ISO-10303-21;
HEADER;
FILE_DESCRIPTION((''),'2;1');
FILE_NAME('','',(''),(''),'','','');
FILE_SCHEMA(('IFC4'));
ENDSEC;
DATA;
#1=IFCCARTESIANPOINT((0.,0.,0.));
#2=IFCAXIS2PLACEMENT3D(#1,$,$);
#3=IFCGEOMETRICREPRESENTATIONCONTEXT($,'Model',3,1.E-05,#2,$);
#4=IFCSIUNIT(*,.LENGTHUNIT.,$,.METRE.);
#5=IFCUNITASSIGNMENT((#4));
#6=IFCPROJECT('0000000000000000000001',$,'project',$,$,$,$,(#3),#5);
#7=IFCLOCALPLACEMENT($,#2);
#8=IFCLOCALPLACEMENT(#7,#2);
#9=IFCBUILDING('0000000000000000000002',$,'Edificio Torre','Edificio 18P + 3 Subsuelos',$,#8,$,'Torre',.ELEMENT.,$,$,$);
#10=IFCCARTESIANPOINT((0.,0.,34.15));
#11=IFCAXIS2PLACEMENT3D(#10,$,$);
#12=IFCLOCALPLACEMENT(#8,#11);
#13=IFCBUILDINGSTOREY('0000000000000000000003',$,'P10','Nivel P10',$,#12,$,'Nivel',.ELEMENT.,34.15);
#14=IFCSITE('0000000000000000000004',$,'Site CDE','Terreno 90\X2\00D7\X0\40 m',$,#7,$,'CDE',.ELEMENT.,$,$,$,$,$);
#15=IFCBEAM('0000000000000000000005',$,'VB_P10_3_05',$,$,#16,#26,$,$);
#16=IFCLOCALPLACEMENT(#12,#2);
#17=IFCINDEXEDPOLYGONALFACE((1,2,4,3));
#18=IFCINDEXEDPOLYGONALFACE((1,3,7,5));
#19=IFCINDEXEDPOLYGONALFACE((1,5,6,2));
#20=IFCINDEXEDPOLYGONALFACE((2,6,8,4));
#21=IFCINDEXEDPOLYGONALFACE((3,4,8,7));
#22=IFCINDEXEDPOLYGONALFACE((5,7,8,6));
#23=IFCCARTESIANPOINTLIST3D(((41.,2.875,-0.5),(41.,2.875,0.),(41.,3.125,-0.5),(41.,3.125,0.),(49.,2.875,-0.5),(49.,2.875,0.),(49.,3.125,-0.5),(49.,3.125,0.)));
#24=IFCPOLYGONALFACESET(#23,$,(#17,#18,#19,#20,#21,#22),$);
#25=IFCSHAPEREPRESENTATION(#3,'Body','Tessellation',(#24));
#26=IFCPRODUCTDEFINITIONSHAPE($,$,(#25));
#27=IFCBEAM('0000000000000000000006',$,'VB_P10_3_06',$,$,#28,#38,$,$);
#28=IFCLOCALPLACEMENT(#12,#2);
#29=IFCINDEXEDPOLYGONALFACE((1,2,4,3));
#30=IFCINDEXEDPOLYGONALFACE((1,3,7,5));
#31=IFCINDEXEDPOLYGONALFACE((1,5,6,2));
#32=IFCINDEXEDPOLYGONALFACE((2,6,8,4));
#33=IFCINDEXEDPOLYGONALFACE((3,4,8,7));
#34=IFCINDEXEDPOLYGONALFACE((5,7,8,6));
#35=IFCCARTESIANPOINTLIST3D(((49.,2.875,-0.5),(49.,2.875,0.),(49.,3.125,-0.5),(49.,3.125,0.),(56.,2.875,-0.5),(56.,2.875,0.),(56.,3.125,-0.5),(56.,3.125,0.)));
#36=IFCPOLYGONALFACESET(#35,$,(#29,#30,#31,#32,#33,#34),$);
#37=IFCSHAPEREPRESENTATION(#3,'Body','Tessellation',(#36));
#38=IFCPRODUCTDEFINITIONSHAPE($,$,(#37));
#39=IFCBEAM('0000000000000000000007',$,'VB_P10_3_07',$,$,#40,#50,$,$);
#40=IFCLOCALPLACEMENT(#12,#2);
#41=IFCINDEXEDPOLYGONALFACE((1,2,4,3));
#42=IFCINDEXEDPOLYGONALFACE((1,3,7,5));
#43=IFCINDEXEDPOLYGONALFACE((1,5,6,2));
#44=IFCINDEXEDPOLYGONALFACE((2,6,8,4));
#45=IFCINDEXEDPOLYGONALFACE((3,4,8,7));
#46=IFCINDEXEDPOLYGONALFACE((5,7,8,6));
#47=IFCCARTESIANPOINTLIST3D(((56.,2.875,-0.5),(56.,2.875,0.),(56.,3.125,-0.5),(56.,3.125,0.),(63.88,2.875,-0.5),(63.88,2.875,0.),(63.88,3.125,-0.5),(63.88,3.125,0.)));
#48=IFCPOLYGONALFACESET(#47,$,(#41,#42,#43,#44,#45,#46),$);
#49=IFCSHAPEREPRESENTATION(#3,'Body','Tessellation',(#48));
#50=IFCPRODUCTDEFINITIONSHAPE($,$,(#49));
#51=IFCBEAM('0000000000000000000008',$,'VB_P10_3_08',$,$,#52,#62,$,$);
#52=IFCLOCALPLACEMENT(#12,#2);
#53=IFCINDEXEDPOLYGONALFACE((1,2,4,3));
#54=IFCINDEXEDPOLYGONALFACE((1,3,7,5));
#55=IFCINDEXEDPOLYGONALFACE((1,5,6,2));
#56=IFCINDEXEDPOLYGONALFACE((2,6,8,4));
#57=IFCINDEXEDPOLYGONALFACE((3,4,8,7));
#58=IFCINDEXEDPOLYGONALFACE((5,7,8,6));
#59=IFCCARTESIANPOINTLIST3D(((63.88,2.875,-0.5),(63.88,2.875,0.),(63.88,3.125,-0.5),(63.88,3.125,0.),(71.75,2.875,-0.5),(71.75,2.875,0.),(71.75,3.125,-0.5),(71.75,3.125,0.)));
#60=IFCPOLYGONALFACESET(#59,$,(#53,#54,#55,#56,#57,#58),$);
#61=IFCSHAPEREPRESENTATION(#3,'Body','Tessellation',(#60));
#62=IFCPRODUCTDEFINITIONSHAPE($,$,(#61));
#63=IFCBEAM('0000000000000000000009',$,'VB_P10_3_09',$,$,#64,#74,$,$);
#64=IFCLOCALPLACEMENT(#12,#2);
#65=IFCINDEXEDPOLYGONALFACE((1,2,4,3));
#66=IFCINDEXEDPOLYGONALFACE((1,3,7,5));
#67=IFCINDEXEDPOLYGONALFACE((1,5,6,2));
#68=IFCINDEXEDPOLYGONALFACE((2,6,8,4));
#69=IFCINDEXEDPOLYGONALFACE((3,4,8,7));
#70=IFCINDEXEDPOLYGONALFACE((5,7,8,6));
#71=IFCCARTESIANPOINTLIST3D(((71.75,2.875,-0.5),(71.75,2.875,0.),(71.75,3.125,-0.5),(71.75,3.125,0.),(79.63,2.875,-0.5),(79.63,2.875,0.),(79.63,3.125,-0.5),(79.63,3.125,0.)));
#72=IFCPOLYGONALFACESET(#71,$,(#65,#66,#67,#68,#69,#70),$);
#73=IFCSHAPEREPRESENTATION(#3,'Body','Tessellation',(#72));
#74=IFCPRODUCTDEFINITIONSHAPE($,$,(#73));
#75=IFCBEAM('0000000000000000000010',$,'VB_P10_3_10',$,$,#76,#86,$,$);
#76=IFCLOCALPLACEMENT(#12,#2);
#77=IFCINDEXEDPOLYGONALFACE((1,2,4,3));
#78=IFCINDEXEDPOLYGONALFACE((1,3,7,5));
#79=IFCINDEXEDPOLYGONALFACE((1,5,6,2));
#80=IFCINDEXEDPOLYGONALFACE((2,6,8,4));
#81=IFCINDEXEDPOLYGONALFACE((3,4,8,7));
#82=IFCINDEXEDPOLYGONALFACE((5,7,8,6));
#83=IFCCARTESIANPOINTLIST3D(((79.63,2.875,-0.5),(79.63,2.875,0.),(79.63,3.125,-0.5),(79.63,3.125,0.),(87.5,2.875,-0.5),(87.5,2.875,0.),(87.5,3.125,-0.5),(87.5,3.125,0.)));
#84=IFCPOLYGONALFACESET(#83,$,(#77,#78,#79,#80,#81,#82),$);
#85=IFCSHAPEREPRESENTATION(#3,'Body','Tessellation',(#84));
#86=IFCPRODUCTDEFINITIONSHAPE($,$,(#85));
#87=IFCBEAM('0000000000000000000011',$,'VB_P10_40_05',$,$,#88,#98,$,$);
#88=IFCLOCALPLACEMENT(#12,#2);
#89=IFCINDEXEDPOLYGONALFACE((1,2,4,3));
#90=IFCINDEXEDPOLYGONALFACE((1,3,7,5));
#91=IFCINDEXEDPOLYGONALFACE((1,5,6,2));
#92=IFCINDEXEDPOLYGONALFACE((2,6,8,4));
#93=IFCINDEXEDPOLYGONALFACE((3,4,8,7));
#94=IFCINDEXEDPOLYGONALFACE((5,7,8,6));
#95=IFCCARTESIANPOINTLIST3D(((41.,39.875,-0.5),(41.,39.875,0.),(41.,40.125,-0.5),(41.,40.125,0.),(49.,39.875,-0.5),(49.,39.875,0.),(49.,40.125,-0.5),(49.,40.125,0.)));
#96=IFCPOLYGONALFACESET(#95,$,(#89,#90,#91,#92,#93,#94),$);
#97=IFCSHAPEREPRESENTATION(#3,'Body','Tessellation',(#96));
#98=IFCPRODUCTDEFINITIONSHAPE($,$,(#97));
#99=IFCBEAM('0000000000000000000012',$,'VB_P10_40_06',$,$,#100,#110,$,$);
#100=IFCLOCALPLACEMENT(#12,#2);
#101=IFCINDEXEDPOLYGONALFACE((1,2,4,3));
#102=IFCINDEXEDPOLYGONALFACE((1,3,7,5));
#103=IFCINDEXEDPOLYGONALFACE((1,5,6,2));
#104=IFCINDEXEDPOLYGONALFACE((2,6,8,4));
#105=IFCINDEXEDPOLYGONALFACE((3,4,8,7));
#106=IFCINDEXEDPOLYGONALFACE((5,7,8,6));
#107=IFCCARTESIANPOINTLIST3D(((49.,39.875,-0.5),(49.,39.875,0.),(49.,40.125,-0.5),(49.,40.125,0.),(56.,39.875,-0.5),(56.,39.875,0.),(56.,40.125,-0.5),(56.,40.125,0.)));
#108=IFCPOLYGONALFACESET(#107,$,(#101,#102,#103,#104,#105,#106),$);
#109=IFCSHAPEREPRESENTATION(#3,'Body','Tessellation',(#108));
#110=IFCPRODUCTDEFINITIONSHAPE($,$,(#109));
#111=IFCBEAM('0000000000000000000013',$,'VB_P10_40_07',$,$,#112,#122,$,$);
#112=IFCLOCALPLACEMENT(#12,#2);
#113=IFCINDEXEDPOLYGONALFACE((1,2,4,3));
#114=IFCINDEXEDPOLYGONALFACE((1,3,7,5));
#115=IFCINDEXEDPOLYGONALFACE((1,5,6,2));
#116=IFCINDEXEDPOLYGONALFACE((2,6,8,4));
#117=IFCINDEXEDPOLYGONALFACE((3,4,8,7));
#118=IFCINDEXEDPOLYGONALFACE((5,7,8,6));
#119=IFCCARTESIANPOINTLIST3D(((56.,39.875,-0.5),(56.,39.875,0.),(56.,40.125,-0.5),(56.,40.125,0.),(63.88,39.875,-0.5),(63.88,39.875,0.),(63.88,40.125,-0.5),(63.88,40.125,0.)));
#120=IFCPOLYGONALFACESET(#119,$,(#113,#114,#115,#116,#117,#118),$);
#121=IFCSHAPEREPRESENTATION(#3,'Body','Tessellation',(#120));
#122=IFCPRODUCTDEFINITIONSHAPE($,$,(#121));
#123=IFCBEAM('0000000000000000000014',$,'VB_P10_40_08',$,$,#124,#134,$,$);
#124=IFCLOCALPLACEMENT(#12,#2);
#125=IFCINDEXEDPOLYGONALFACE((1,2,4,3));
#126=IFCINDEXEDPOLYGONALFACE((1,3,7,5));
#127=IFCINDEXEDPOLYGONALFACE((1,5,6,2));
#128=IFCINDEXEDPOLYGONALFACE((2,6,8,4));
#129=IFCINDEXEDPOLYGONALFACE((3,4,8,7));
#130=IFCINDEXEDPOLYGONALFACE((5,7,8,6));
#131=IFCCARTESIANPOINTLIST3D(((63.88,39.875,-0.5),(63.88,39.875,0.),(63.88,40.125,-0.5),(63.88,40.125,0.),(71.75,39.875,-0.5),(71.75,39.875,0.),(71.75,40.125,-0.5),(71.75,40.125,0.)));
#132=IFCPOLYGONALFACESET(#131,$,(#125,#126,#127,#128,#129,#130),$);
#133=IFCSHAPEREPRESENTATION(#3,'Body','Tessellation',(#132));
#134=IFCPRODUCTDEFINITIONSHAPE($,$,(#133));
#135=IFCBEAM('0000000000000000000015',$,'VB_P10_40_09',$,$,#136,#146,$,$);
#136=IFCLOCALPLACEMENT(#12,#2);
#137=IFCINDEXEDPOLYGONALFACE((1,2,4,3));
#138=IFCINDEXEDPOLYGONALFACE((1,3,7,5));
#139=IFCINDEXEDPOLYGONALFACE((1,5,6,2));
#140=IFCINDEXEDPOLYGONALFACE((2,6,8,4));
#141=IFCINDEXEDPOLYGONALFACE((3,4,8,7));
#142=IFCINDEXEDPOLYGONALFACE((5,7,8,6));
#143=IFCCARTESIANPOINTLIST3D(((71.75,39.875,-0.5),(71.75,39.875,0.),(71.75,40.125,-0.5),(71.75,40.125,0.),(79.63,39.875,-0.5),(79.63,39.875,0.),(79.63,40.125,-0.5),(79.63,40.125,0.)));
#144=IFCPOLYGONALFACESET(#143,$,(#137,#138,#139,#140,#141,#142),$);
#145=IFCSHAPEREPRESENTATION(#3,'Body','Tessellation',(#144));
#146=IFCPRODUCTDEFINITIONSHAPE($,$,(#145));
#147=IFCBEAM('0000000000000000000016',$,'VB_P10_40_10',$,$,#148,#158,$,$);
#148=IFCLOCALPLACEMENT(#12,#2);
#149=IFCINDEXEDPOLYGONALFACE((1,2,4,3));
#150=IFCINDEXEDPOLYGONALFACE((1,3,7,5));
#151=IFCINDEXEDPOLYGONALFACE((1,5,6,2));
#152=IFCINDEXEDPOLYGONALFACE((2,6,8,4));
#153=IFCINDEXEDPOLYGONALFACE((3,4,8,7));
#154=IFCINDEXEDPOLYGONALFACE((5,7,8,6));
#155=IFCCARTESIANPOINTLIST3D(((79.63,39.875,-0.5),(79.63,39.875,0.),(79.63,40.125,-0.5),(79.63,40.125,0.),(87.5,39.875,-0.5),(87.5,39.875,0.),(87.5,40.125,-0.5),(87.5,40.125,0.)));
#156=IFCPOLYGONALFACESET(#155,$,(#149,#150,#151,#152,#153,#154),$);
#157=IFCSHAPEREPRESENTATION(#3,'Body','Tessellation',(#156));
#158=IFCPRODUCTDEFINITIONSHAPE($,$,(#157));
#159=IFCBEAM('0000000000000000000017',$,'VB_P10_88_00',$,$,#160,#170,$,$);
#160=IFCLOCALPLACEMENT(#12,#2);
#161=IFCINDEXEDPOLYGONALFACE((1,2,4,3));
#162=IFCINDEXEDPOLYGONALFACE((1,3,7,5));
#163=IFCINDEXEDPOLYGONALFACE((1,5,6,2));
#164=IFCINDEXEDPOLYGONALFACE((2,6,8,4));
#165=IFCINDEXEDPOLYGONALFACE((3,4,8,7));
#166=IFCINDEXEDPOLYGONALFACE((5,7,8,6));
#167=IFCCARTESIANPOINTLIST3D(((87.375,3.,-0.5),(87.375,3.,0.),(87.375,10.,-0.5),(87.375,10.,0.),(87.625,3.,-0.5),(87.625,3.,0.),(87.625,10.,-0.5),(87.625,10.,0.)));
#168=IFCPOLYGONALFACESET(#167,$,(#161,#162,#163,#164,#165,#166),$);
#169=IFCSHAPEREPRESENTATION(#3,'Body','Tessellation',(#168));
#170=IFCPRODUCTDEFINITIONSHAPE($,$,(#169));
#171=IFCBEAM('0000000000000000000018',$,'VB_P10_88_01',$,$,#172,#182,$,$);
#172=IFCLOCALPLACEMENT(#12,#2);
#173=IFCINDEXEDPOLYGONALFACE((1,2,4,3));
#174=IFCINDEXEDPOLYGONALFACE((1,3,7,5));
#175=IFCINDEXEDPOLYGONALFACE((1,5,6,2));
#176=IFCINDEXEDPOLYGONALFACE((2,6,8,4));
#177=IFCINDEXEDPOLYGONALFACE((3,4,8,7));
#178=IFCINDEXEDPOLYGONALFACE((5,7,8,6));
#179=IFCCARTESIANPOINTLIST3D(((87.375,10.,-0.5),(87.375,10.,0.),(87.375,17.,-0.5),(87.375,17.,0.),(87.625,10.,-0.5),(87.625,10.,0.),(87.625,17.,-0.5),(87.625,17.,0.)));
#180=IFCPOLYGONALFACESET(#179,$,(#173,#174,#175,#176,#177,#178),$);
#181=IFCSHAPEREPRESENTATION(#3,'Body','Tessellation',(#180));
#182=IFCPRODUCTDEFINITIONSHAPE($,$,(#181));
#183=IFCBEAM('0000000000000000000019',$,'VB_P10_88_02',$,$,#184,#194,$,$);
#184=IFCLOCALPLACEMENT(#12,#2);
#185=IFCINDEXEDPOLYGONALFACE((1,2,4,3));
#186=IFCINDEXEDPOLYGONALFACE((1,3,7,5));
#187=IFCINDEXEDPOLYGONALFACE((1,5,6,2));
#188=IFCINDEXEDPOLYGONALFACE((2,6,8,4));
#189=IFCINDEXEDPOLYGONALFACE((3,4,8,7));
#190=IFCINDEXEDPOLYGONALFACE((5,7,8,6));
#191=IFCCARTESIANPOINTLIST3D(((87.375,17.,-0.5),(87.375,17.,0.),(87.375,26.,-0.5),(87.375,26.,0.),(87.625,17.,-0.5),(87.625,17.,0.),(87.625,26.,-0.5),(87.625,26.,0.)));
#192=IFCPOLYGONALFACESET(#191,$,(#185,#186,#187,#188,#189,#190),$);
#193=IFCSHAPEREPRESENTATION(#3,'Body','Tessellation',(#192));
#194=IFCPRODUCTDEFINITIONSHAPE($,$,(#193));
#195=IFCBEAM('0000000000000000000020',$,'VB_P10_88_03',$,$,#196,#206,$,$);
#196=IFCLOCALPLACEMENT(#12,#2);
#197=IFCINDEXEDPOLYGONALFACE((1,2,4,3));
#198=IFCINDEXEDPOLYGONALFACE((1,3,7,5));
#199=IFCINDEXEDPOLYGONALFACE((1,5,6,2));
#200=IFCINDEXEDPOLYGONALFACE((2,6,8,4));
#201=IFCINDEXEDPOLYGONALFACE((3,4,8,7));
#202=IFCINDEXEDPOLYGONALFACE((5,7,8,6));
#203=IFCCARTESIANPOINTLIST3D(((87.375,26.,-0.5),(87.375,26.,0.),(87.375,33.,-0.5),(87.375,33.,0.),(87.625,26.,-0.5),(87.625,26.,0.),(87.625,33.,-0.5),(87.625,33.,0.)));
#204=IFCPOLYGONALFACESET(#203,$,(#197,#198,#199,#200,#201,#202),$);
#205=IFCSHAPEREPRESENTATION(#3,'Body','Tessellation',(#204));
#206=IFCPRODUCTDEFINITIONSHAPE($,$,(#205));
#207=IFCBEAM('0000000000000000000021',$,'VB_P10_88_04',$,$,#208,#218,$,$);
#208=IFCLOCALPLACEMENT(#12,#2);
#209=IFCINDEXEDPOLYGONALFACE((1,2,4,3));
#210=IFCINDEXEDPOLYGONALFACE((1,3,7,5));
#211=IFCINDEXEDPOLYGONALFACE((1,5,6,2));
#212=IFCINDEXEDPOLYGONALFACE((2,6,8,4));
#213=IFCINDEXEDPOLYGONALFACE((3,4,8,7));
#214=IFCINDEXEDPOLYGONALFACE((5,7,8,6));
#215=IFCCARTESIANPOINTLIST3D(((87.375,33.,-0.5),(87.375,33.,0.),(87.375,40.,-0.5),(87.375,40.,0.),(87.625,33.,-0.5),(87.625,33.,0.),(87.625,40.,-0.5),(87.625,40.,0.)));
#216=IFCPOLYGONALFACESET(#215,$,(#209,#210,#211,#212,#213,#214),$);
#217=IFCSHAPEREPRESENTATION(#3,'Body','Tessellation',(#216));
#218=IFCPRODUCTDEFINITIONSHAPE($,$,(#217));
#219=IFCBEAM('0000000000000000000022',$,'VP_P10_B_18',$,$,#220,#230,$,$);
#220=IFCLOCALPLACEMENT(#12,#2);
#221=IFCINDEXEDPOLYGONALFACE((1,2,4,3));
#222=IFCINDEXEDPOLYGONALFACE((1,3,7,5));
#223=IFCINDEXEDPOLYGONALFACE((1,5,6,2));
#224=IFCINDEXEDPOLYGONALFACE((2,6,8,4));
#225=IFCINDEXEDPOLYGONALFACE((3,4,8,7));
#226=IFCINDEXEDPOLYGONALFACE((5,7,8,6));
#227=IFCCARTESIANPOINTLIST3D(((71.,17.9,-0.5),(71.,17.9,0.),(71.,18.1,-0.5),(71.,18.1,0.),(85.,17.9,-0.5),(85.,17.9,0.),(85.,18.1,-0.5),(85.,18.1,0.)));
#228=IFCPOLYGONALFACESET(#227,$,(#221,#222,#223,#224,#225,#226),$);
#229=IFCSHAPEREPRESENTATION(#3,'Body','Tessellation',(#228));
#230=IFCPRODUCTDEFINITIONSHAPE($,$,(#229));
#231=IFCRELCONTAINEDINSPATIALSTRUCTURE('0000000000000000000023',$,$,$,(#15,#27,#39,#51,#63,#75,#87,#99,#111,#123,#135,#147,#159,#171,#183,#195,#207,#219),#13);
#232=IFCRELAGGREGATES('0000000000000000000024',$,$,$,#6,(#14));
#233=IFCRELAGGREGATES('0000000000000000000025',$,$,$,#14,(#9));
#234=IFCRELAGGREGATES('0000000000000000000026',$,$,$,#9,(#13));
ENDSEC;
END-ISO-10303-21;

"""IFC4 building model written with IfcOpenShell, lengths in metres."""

from ifc_helpers import new_model, si_unit, frame, origin, origin_2d, place, context, project, spatial, rectangle, extrude, element, save


model = new_model("IFC4")

# Units and contexts
model_context = context("Model", 3, precision=1e-05, world=origin())
ifc_project = project(units=[si_unit("LENGTHUNIT", "METRE")], contexts=[model_context])

# Site, building, storey
site_placement = place(None, origin())
site = spatial("IfcSite", under=ifc_project, at=site_placement, Name="Site CDE", Description="Terreno 90×40 m", LongName="CDE", CompositionType="ELEMENT")
building_placement = place(site_placement, origin())
building = spatial("IfcBuilding", under=site, at=building_placement, Name="Edificio Torre", Description="Edificio 18P + 3 Subsuelos", LongName="Torre", CompositionType="ELEMENT")
storey_placement = place(building_placement, frame((0.0, 0.0, 34.15)))
storey = spatial("IfcBuildingStorey", under=building, at=storey_placement, Name="P10", Description="Nivel P10", LongName="Nivel", CompositionType="ELEMENT", Elevation=34.15)

# Beams
beam_1_placement = place(storey_placement, frame((45.0, 3.0, -0.5)))
element("IfcBeam", 1, at=beam_1_placement, inside=storey, Name="VB_P10_3_05", context=model_context, shape_type="SweptSolid", body=[
    extrude(rectangle(XDim=8.0, YDim=0.25, at=origin_2d()), origin(), (0.0, 0.0, 1.0), 0.5),
])
beam_2_placement = place(storey_placement, frame((52.5, 3.0, -0.5)))
element("IfcBeam", 2, at=beam_2_placement, inside=storey, Name="VB_P10_3_06", context=model_context, shape_type="SweptSolid", body=[
    extrude(rectangle(XDim=7.0, YDim=0.25, at=origin_2d()), origin(), (0.0, 0.0, 1.0), 0.5),
])
beam_3_placement = place(storey_placement, frame((59.94, 3.0, -0.5)))
element("IfcBeam", 3, at=beam_3_placement, inside=storey, Name="VB_P10_3_07", context=model_context, shape_type="SweptSolid", body=[
    extrude(rectangle(XDim=7.88, YDim=0.25, at=origin_2d()), origin(), (0.0, 0.0, 1.0), 0.5),
])
beam_4_placement = place(storey_placement, frame((67.815, 3.0, -0.5)))
element("IfcBeam", 4, at=beam_4_placement, inside=storey, Name="VB_P10_3_08", context=model_context, shape_type="SweptSolid", body=[
    extrude(rectangle(XDim=7.87, YDim=0.25, at=origin_2d()), origin(), (0.0, 0.0, 1.0), 0.5),
])
beam_5_placement = place(storey_placement, frame((75.69, 3.0, -0.5)))
element("IfcBeam", 5, at=beam_5_placement, inside=storey, Name="VB_P10_3_09", context=model_context, shape_type="SweptSolid", body=[
    extrude(rectangle(XDim=7.88, YDim=0.25, at=origin_2d()), origin(), (0.0, 0.0, 1.0), 0.5),
])
beam_6_placement = place(storey_placement, frame((83.565, 3.0, -0.5)))
element("IfcBeam", 6, at=beam_6_placement, inside=storey, Name="VB_P10_3_10", context=model_context, shape_type="SweptSolid", body=[
    extrude(rectangle(XDim=7.87, YDim=0.25, at=origin_2d()), origin(), (0.0, 0.0, 1.0), 0.5),
])
beam_7_placement = place(storey_placement, frame((45.0, 40.0, -0.5)))
element("IfcBeam", 7, at=beam_7_placement, inside=storey, Name="VB_P10_40_05", context=model_context, shape_type="SweptSolid", body=[
    extrude(rectangle(XDim=8.0, YDim=0.25, at=origin_2d()), origin(), (0.0, 0.0, 1.0), 0.5),
])
beam_8_placement = place(storey_placement, frame((52.5, 40.0, -0.5)))
element("IfcBeam", 8, at=beam_8_placement, inside=storey, Name="VB_P10_40_06", context=model_context, shape_type="SweptSolid", body=[
    extrude(rectangle(XDim=7.0, YDim=0.25, at=origin_2d()), origin(), (0.0, 0.0, 1.0), 0.5),
])
beam_9_placement = place(storey_placement, frame((59.94, 40.0, -0.5)))
element("IfcBeam", 9, at=beam_9_placement, inside=storey, Name="VB_P10_40_07", context=model_context, shape_type="SweptSolid", body=[
    extrude(rectangle(XDim=7.88, YDim=0.25, at=origin_2d()), origin(), (0.0, 0.0, 1.0), 0.5),
])
beam_10_placement = place(storey_placement, frame((67.815, 40.0, -0.5)))
element("IfcBeam", 10, at=beam_10_placement, inside=storey, Name="VB_P10_40_08", context=model_context, shape_type="SweptSolid", body=[
    extrude(rectangle(XDim=7.87, YDim=0.25, at=origin_2d()), origin(), (0.0, 0.0, 1.0), 0.5),
])
beam_11_placement = place(storey_placement, frame((75.69, 40.0, -0.5)))
element("IfcBeam", 11, at=beam_11_placement, inside=storey, Name="VB_P10_40_09", context=model_context, shape_type="SweptSolid", body=[
    extrude(rectangle(XDim=7.88, YDim=0.25, at=origin_2d()), origin(), (0.0, 0.0, 1.0), 0.5),
])
beam_12_placement = place(storey_placement, frame((83.565, 40.0, -0.5)))
element("IfcBeam", 12, at=beam_12_placement, inside=storey, Name="VB_P10_40_10", context=model_context, shape_type="SweptSolid", body=[
    extrude(rectangle(XDim=7.87, YDim=0.25, at=origin_2d()), origin(), (0.0, 0.0, 1.0), 0.5),
])
for number, where, name in (
    (13, (87.5, 6.5, -0.5), "VB_P10_88_00"),
    (14, (87.5, 13.5, -0.5), "VB_P10_88_01"),
):
    element("IfcBeam", number, at=place(storey_placement, frame(where)), inside=storey, Name=name, context=model_context, shape_type="SweptSolid", body=[
        extrude(rectangle(XDim=0.25, YDim=7.0, at=origin_2d()), origin(), (0.0, 0.0, 1.0), 0.5),
    ])
beam_13_placement = place(storey_placement, frame((87.5, 21.5, -0.5)))
element("IfcBeam", 15, at=beam_13_placement, inside=storey, Name="VB_P10_88_02", context=model_context, shape_type="SweptSolid", body=[
    extrude(rectangle(XDim=0.25, YDim=9.0, at=origin_2d()), origin(), (0.0, 0.0, 1.0), 0.5),
])
for number, where, name in (
    (16, (87.5, 29.5, -0.5), "VB_P10_88_03"),
    (17, (87.5, 36.5, -0.5), "VB_P10_88_04"),
):
    element("IfcBeam", number, at=place(storey_placement, frame(where)), inside=storey, Name=name, context=model_context, shape_type="SweptSolid", body=[
        extrude(rectangle(XDim=0.25, YDim=7.0, at=origin_2d()), origin(), (0.0, 0.0, 1.0), 0.5),
    ])
for number, where, name in (
    (18, (78.0, 18.0, -0.5), "VP_P10_B_18"),
):
    element("IfcBeam", number, at=place(storey_placement, frame(where)), inside=storey, Name=name, context=model_context, shape_type="SweptSolid", body=[
        extrude(rectangle(XDim=14.0, YDim=0.2, at=origin_2d()), origin(), (0.0, 0.0, 1.0), 0.5),
    ])

save(model, "model.ifc")
